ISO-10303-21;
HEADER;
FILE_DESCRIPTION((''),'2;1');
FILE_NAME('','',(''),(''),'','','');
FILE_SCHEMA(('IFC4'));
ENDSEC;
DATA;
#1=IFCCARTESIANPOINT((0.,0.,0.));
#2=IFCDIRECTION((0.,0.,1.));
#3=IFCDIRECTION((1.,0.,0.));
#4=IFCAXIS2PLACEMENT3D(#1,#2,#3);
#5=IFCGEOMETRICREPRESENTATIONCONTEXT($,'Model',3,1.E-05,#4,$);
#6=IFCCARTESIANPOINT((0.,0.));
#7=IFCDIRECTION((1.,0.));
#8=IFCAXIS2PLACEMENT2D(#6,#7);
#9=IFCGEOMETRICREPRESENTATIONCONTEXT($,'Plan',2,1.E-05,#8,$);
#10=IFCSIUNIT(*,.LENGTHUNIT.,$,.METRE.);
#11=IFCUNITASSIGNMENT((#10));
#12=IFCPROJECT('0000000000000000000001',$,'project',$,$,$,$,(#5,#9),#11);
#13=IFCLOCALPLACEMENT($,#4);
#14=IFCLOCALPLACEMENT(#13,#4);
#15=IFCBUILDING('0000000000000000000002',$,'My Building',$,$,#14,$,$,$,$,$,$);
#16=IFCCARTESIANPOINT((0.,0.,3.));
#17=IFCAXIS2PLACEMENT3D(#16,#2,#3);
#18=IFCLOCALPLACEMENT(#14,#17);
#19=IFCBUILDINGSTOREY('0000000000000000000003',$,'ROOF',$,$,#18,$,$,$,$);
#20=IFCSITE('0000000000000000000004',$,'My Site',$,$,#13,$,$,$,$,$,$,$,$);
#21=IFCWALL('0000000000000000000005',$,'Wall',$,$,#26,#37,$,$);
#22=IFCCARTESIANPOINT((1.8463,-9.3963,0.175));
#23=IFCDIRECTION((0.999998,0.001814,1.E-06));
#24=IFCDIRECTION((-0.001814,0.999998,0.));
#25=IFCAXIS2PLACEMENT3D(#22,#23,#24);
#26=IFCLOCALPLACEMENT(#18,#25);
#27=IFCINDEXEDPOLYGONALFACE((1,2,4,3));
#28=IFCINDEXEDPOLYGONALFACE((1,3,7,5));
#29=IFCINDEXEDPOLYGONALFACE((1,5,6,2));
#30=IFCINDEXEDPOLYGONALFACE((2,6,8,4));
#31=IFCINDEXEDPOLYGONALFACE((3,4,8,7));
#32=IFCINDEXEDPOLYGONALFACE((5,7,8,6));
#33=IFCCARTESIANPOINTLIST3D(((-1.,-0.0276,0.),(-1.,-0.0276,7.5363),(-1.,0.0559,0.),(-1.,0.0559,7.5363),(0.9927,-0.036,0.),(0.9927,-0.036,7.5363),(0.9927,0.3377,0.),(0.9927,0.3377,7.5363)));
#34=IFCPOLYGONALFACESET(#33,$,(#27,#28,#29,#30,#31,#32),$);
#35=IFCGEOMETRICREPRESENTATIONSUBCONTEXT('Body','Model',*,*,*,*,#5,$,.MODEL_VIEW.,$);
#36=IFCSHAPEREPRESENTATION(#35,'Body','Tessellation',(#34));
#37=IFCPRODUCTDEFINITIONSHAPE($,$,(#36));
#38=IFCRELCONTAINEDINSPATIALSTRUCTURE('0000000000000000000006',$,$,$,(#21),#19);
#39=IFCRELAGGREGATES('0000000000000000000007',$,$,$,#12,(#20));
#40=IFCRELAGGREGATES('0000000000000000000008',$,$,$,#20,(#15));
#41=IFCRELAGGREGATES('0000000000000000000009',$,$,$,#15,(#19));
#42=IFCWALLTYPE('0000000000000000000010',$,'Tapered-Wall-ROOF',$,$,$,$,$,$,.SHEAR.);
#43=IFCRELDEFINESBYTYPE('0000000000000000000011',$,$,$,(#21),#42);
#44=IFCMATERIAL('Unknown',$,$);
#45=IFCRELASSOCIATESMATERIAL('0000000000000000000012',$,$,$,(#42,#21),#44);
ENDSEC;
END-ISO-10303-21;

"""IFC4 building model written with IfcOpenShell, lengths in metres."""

from ifc_helpers import new_model, si_unit, frame, origin_with_axes, origin_2d_with_axis, place, context, subcontext, project, spatial, indexed_curve, outline, extrude, material, material_profile, profile_set, profile_usage, type_object, element, save


model = new_model("IFC4")

# Units and contexts
model_context = context("Model", 3, precision=1e-05, world=origin_with_axes())
plan_context = context("Plan", 2, precision=1e-05, world=origin_2d_with_axis())
body_context = subcontext(model_context, "Body", "Model", "MODEL_VIEW")
ifc_project = project(units=[si_unit("LENGTHUNIT", "METRE")], contexts=[model_context, plan_context])

# Site, building, storey
site_placement = place(None, origin_with_axes())
site = spatial("IfcSite", under=ifc_project, at=site_placement, Name="My Site")
building_placement = place(site_placement, origin_with_axes())
building = spatial("IfcBuilding", under=site, at=building_placement, Name="My Building")
storey_placement = place(building_placement, frame((0.0, 0.0, 3.0), z_axis=(0.0, 0.0, 1.0), x_axis=(1.0, 0.0, 0.0)))
storey = spatial("IfcBuildingStorey", under=building, at=storey_placement, Name="ROOF")

# Shared definitions
ifc_material = material(Name="Unknown")

# Wall
ifc_material_profile_1 = material_profile(ifc_material, outline(indexed_curve([(-1.0, -0.0276), (0.9927, -0.036), (0.9927, 0.3377), (-1.0, 0.0559), (-1.0, -0.0276)])))
ifc_profile_set_1 = profile_set([ifc_material_profile_1])
ifc_profile_usage_1 = profile_usage(ifc_profile_set_1, cardinal=5)
wall_type = type_object("IfcWallType", Name="Tapered-Wall-ROOF", PredefinedType="SHEAR", material=ifc_profile_set_1)
wall_placement = place(storey_placement, frame((1.8463, -9.3963, 0.175), z_axis=(0.999998, 0.001814, 0.000001), x_axis=(-0.001814, 0.999998, 0.0)))
element("IfcWall", 1, at=wall_placement, inside=storey, type_object=wall_type, material=ifc_profile_usage_1, Name="Wall", context=body_context, shape_type="SweptSolid", body=[
    extrude(outline(indexed_curve([(-1.0, -0.0276), (0.9927, -0.036), (0.9927, 0.3377), (-1.0, 0.0559), (-1.0, -0.0276)])), origin_with_axes(), (0.0, 0.0, 1.0), 7.5363),
])

save(model, "model.ifc")
